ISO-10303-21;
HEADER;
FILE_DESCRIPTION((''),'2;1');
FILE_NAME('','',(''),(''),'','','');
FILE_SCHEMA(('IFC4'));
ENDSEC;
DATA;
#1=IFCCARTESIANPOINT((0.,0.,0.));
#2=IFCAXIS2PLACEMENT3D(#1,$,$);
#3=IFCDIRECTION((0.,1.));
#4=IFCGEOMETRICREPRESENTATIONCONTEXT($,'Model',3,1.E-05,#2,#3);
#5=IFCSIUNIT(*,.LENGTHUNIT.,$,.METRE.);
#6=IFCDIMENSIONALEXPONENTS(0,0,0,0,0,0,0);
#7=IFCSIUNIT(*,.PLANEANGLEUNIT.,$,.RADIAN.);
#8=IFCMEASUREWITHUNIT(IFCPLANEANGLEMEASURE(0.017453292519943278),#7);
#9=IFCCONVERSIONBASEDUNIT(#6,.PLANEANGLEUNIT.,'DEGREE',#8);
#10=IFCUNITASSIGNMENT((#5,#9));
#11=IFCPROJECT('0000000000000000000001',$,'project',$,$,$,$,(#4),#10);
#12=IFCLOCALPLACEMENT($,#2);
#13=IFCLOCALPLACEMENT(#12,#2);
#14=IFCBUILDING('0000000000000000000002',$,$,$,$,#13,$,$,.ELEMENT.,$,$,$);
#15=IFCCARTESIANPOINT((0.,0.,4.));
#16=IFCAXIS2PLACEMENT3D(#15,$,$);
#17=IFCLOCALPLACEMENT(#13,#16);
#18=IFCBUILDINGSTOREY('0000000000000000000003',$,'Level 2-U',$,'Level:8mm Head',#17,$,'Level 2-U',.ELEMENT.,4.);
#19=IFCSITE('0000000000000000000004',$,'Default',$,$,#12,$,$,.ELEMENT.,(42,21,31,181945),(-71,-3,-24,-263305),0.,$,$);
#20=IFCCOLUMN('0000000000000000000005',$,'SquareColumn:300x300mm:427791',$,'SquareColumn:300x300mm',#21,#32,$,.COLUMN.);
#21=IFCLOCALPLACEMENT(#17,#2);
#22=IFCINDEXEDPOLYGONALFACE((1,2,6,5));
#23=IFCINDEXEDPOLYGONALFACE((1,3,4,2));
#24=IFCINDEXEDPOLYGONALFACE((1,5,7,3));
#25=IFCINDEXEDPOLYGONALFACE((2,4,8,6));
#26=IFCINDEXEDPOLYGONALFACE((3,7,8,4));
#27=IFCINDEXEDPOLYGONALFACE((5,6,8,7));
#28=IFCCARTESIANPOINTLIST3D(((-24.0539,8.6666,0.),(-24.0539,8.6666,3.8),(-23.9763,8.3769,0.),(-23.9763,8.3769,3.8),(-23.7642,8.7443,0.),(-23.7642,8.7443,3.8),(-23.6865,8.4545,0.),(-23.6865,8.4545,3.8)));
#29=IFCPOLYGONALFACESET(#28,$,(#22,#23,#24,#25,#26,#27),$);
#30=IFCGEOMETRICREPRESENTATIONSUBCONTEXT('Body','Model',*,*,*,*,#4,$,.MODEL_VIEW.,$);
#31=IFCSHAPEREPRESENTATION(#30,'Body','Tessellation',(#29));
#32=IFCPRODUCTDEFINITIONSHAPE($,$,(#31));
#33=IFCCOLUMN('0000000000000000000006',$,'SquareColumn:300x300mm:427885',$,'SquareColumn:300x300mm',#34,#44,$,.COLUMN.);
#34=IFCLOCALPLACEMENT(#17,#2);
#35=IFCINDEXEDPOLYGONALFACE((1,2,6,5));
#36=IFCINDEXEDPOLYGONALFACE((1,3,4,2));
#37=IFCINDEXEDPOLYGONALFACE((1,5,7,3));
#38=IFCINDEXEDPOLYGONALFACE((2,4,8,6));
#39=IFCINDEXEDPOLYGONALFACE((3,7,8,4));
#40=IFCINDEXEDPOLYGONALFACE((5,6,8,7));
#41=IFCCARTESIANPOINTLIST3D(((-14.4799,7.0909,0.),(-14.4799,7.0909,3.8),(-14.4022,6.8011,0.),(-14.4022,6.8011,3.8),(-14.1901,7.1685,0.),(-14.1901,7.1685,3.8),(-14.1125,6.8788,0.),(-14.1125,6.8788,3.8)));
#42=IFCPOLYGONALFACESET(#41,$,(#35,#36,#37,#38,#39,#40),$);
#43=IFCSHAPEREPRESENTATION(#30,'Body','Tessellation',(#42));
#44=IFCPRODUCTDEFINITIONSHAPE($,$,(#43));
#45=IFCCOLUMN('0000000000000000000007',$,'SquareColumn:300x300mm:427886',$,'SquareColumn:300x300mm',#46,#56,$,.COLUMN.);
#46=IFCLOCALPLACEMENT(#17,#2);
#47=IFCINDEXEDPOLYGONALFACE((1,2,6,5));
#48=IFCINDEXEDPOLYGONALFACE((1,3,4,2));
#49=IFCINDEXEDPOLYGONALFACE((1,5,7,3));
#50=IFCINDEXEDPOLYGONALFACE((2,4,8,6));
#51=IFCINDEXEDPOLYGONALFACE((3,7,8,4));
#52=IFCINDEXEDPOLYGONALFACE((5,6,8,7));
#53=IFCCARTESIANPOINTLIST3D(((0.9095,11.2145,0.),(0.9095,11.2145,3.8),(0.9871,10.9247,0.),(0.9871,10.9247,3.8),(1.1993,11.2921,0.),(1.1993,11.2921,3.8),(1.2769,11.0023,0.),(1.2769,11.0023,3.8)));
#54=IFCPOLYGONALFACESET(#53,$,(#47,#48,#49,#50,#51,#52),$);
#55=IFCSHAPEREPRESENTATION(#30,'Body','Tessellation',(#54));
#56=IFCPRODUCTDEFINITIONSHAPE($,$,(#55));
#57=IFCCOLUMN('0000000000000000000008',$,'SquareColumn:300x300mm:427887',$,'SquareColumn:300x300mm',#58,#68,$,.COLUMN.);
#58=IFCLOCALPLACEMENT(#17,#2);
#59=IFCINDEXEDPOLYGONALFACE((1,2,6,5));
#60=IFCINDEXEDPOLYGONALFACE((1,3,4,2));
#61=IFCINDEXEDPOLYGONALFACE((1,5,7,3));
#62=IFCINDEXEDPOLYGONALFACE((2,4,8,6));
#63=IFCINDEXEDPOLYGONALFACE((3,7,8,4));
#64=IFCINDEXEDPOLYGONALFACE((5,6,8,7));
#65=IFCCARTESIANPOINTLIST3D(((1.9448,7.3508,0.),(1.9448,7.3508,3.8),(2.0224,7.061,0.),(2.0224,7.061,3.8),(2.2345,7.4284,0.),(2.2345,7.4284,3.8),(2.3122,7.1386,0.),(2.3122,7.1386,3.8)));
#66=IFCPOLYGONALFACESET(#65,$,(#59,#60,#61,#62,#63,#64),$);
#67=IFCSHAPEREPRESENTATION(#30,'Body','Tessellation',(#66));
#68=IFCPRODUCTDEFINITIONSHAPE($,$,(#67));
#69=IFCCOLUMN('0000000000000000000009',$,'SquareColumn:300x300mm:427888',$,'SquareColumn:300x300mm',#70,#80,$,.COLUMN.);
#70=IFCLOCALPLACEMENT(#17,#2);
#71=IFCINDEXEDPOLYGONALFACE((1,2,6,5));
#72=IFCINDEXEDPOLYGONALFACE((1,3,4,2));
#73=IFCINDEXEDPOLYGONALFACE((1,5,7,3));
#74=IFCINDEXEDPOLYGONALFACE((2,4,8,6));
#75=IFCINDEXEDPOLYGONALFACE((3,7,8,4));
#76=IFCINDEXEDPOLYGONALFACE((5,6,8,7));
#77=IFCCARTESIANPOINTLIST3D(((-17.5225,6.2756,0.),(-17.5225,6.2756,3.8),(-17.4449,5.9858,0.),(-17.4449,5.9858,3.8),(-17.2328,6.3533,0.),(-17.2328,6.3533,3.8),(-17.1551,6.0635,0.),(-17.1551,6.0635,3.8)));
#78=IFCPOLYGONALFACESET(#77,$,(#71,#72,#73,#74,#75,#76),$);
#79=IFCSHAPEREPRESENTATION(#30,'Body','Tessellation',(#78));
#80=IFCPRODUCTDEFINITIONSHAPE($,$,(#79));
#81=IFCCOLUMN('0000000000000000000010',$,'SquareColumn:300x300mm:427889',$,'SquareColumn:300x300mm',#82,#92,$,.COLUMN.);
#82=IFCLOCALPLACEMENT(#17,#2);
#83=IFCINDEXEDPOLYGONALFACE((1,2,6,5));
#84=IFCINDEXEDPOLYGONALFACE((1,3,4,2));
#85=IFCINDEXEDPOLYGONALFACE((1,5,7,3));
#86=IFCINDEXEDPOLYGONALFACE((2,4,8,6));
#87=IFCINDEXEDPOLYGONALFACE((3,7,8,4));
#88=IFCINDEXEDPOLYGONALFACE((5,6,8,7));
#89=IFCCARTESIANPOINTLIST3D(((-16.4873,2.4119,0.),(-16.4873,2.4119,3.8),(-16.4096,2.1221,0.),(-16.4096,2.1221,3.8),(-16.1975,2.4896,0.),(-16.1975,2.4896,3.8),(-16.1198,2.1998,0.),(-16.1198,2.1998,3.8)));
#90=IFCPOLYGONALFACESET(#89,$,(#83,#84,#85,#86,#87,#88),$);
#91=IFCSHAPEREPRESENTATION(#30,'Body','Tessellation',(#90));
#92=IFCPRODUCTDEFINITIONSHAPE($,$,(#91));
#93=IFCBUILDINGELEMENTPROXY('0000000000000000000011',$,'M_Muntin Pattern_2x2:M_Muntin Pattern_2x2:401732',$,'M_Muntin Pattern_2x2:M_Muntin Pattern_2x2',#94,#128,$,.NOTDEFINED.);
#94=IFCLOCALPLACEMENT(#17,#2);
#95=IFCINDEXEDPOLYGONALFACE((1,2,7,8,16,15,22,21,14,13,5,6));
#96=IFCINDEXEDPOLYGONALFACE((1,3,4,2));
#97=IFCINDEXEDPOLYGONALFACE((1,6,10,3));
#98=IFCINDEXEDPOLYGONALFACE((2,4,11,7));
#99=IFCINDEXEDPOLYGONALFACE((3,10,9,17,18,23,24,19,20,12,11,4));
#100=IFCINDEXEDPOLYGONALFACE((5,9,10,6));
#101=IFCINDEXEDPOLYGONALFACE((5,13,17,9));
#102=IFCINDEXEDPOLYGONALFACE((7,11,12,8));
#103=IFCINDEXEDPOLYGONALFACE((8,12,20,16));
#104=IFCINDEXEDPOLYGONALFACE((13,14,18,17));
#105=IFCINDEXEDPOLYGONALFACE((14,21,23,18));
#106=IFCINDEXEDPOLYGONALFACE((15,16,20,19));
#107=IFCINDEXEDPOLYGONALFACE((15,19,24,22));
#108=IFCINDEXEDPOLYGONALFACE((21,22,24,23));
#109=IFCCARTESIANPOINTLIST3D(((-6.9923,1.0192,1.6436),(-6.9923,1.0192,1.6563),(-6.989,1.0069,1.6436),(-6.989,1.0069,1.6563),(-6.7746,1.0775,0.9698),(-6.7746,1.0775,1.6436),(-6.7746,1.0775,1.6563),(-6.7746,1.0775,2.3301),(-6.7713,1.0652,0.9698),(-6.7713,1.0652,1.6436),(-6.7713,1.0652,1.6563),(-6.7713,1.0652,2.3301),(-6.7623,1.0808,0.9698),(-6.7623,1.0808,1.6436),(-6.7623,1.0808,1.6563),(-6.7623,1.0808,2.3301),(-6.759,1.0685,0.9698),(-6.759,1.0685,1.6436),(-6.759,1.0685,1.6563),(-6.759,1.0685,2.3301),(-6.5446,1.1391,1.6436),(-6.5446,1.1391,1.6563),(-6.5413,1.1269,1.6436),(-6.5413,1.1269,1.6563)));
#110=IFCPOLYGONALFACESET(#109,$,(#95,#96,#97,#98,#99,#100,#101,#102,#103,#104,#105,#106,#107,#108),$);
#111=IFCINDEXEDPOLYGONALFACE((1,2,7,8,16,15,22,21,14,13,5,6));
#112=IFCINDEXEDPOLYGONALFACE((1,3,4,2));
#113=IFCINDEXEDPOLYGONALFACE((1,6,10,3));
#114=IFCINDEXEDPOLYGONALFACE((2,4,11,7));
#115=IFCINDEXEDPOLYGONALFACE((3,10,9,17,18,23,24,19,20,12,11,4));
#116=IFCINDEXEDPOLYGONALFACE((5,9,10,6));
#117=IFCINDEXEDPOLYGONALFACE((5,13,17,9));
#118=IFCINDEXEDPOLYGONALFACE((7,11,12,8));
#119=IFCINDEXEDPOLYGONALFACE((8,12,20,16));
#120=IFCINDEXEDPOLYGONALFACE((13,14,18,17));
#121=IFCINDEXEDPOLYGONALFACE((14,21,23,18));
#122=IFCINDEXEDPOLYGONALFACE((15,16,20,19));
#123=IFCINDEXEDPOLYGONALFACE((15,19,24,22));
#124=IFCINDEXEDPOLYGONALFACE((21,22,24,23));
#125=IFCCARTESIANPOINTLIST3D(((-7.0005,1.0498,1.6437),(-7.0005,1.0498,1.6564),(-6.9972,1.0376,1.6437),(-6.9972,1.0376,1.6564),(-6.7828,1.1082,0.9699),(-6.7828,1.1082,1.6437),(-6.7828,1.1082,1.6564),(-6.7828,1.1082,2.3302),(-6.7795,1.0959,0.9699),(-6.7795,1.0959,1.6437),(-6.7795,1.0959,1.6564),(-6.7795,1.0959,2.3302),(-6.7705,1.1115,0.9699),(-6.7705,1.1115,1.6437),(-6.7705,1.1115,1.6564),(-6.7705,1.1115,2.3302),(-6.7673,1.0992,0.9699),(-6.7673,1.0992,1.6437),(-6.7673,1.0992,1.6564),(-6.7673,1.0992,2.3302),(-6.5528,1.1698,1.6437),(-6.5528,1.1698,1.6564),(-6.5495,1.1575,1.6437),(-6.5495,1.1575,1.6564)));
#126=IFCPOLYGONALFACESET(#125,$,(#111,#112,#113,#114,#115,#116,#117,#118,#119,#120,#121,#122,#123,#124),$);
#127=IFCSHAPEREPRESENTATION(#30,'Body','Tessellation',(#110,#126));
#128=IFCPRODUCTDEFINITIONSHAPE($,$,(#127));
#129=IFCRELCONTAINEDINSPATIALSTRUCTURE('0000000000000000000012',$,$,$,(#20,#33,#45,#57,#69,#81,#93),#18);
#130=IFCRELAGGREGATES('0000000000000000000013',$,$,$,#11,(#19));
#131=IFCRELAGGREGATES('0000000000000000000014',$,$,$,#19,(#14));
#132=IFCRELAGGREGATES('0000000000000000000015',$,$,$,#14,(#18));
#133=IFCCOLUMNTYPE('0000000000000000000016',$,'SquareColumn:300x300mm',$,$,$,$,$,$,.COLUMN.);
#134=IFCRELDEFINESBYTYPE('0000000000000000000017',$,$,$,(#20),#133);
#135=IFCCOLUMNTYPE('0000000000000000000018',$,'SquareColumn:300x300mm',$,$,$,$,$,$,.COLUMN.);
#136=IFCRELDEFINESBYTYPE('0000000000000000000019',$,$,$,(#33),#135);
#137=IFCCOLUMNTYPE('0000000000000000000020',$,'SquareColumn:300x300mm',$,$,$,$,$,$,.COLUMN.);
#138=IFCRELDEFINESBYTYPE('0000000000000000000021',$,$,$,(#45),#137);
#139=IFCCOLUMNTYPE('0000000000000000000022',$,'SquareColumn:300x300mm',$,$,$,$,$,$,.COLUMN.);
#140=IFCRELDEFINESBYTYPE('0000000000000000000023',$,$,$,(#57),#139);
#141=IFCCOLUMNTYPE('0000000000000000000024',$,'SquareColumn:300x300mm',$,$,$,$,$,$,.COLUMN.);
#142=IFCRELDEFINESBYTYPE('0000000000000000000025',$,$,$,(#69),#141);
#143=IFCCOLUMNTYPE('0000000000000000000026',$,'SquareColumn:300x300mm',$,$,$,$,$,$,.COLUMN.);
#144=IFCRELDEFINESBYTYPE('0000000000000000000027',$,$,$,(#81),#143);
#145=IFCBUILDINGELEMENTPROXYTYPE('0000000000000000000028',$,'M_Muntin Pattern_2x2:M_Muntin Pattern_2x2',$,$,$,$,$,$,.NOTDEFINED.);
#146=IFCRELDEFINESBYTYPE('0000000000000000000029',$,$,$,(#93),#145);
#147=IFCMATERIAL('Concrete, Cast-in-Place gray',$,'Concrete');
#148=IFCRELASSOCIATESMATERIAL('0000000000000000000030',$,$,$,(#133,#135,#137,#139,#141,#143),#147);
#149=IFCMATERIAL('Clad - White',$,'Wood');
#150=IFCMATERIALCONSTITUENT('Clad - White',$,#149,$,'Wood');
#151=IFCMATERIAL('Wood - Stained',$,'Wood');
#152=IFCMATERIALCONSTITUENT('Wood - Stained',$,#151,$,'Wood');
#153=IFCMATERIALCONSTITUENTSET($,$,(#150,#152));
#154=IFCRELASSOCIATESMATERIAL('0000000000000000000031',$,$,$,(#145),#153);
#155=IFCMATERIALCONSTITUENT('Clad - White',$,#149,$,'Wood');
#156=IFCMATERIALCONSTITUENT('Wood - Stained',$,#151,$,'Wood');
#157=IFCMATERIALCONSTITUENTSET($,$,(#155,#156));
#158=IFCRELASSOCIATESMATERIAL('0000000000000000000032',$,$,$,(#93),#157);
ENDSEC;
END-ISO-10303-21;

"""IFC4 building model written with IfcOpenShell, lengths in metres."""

from ifc_helpers import new_model, entity, si_unit, converted_unit, direction, frame, frame_2d, origin, origin_2d_with_axis, place, context, subcontext, project, spatial, polyline, rectangle, outline, extrude, source, transform, mapped, material, constituent, constituent_set, material_profile, profile_set, type_object, type_shapes, element, save


model = new_model("IFC4")

# Units and contexts
model_context = context("Model", 3, precision=1e-05, world=origin(), true_north=direction((0.0, 1.0)))
body_context = subcontext(model_context, "Body", "Model", "MODEL_VIEW")
ifc_project = project(units=[si_unit("LENGTHUNIT", "METRE"), converted_unit("PLANEANGLEUNIT", "DEGREE", entity("IfcPlaneAngleMeasure", 0.017453292519943278), si_unit("PLANEANGLEUNIT", "RADIAN"), dimensions=[0, 0, 0, 0, 0, 0, 0])], contexts=[model_context])

# Site, building, storey
site_placement = place(None, origin())
site = spatial("IfcSite", under=ifc_project, at=site_placement, Name="Default", CompositionType="ELEMENT", RefLatitude=(42, 21, 31, 181945), RefLongitude=(-71, -3, -24, -263305), RefElevation=0.0)
building_placement = place(site_placement, origin())
building = spatial("IfcBuilding", under=site, at=building_placement, CompositionType="ELEMENT")
storey_placement = place(building_placement, frame((0.0, 0.0, 4.0)))
storey = spatial("IfcBuildingStorey", under=building, at=storey_placement, Name="Level 2-U", ObjectType="Level:8mm Head", LongName="Level 2-U", CompositionType="ELEMENT", Elevation=4.0)

# Columns
ifc_material_1 = material(Name="Concrete, Cast-in-Place gray", Category="Concrete")
ifc_material_profile = material_profile(ifc_material_1, rectangle(XDim=0.3, YDim=0.3, at=origin_2d_with_axis()), Name="300x300mm")
ifc_profile_set = profile_set([ifc_material_profile], Name="300x300mm")
column_type_1 = type_object("IfcColumnType", Name="SquareColumn:300x300mm", PredefinedType="COLUMN", material=ifc_profile_set)
shared_shape_1 = source(origin(), body_context, "Body", "SweptSolid", [
    extrude(rectangle(XDim=0.3, YDim=0.3, at=origin_2d_with_axis()), frame((-23.8702, 8.5606, 4.0), z_axis=(0.0, 0.0, 1.0), x_axis=(-0.258819, 0.965926, 0.0)), (0.0, 0.0, 1.0), 3.8),
])
type_shapes(column_type_1, [shared_shape_1])
column_1_placement = place(storey_placement, frame((0.0, 0.0, -4.0)))
element("IfcColumn", 1, at=column_1_placement, inside=storey, type_object=column_type_1, Name="SquareColumn:300x300mm:427791", ObjectType="SquareColumn:300x300mm", PredefinedType="COLUMN", context=body_context, shape_type="MappedRepresentation", body=[
    mapped(shared_shape_1, transform((0.0, 0.0, 0.0), scale=1.0)),
])
column_type_2 = type_object("IfcColumnType", Name="SquareColumn:300x300mm", PredefinedType="COLUMN", material=ifc_profile_set)
shared_shape_2 = source(origin(), body_context, "Body", "SweptSolid", [
    extrude(rectangle(XDim=0.3, YDim=0.3, at=frame_2d((0.0, 0.0), x_axis=(1.0, 0.0))), frame((-14.2962, 6.9848, 4.0), z_axis=(0.0, 0.0, 1.0), x_axis=(-0.258819, 0.965926, 0.0)), (0.0, 0.0, 1.0), 3.8),
])
type_shapes(column_type_2, [shared_shape_2])
column_2_placement = place(storey_placement, frame((0.0, 0.0, -4.0)))
element("IfcColumn", 2, at=column_2_placement, inside=storey, type_object=column_type_2, Name="SquareColumn:300x300mm:427885", ObjectType="SquareColumn:300x300mm", PredefinedType="COLUMN", context=body_context, shape_type="MappedRepresentation", body=[
    mapped(shared_shape_2, transform((0.0, 0.0, 0.0), scale=1.0)),
])
column_type_3 = type_object("IfcColumnType", Name="SquareColumn:300x300mm", PredefinedType="COLUMN", material=ifc_profile_set)
shared_shape_3 = source(origin(), body_context, "Body", "SweptSolid", [
    extrude(rectangle(XDim=0.3, YDim=0.3, at=frame_2d((0.0, 0.0), x_axis=(1.0, 0.0))), frame((1.0932, 11.1084, 4.0), z_axis=(0.0, 0.0, 1.0), x_axis=(-0.258819, 0.965926, 0.0)), (0.0, 0.0, 1.0), 3.8),
])
type_shapes(column_type_3, [shared_shape_3])
column_3_placement = place(storey_placement, frame((0.0, 0.0, -4.0)))
element("IfcColumn", 3, at=column_3_placement, inside=storey, type_object=column_type_3, Name="SquareColumn:300x300mm:427886", ObjectType="SquareColumn:300x300mm", PredefinedType="COLUMN", context=body_context, shape_type="MappedRepresentation", body=[
    mapped(shared_shape_3, transform((0.0, 0.0, 0.0), scale=1.0)),
])
column_type_4 = type_object("IfcColumnType", Name="SquareColumn:300x300mm", PredefinedType="COLUMN", material=ifc_profile_set)
shared_shape_4 = source(origin(), body_context, "Body", "SweptSolid", [
    extrude(rectangle(XDim=0.3, YDim=0.3, at=frame_2d((0.0, 0.0), x_axis=(1.0, 0.0))), frame((2.1285, 7.2447, 4.0), z_axis=(0.0, 0.0, 1.0), x_axis=(-0.258819, 0.965926, 0.0)), (0.0, 0.0, 1.0), 3.8),
])
type_shapes(column_type_4, [shared_shape_4])
column_4_placement = place(storey_placement, frame((0.0, 0.0, -4.0)))
element("IfcColumn", 4, at=column_4_placement, inside=storey, type_object=column_type_4, Name="SquareColumn:300x300mm:427887", ObjectType="SquareColumn:300x300mm", PredefinedType="COLUMN", context=body_context, shape_type="MappedRepresentation", body=[
    mapped(shared_shape_4, transform((0.0, 0.0, 0.0), scale=1.0)),
])
column_type_5 = type_object("IfcColumnType", Name="SquareColumn:300x300mm", PredefinedType="COLUMN", material=ifc_profile_set)
shared_shape_5 = source(origin(), body_context, "Body", "SweptSolid", [
    extrude(rectangle(XDim=0.3, YDim=0.3, at=origin_2d_with_axis()), frame((-17.3388, 6.1695, 4.0), z_axis=(0.0, 0.0, 1.0), x_axis=(-0.258819, 0.965926, 0.0)), (0.0, 0.0, 1.0), 3.8),
])
type_shapes(column_type_5, [shared_shape_5])
column_5_placement = place(storey_placement, frame((0.0, 0.0, -4.0)))
element("IfcColumn", 5, at=column_5_placement, inside=storey, type_object=column_type_5, Name="SquareColumn:300x300mm:427888", ObjectType="SquareColumn:300x300mm", PredefinedType="COLUMN", context=body_context, shape_type="MappedRepresentation", body=[
    mapped(shared_shape_5, transform((0.0, 0.0, 0.0), scale=1.0)),
])
column_type_6 = type_object("IfcColumnType", Name="SquareColumn:300x300mm", PredefinedType="COLUMN", material=ifc_profile_set)
shared_shape_6 = source(origin(), body_context, "Body", "SweptSolid", [
    extrude(rectangle(XDim=0.3, YDim=0.3, at=origin_2d_with_axis()), frame((-16.3036, 2.3058, 4.0), z_axis=(0.0, 0.0, 1.0), x_axis=(-0.258819, 0.965926, 0.0)), (0.0, 0.0, 1.0), 3.8),
])
type_shapes(column_type_6, [shared_shape_6])
column_6_placement = place(storey_placement, frame((0.0, 0.0, -4.0)))
element("IfcColumn", 6, at=column_6_placement, inside=storey, type_object=column_type_6, Name="SquareColumn:300x300mm:427889", ObjectType="SquareColumn:300x300mm", PredefinedType="COLUMN", context=body_context, shape_type="MappedRepresentation", body=[
    mapped(shared_shape_6, transform((0.0, 0.0, 0.0), scale=1.0)),
])

# Building element proxy
ifc_material_2 = material(Name="Clad - White", Category="Wood")
ifc_constituent_1 = constituent(ifc_material_2, Name="Clad - White", Category="Wood")
ifc_material_3 = material(Name="Wood - Stained", Category="Wood")
ifc_constituent_2 = constituent(ifc_material_3, Name="Wood - Stained", Category="Wood")
ifc_constituent_set_1 = constituent_set(constituents=[ifc_constituent_1, ifc_constituent_2])
ifc_constituent_3 = constituent(ifc_material_2, Name="Clad - White", Category="Wood")
ifc_constituent_4 = constituent(ifc_material_3, Name="Wood - Stained", Category="Wood")
ifc_constituent_set_2 = constituent_set(constituents=[ifc_constituent_3, ifc_constituent_4])
building_element_proxy_type = type_object("IfcBuildingElementProxyType", Name="M_Muntin Pattern_2x2:M_Muntin Pattern_2x2", PredefinedType="NOTDEFINED", material=ifc_constituent_set_2)
shared_shape_7 = source(origin(), body_context, "Body", "SweptSolid", [
    extrude(outline(polyline([(0.0064, -0.0064), (0.6801, -0.0064), (0.6801, 0.0063), (0.0064, 0.0063), (0.0064, 0.2317), (-0.0063, 0.2317), (-0.0063, 0.0063), (-0.6802, 0.0063), (-0.6802, -0.0064), (-0.0063, -0.0064), (-0.0063, -0.2317), (0.0064, -0.2317), (0.0064, -0.0064)])), frame((0.0, -0.0222, 0.6801), z_axis=(0.0, 1.0, 0.0), x_axis=(0.0, 0.0, 1.0)), (0.0, 0.0, 1.0), 0.0127),
    extrude(outline(polyline([(0.0064, -0.0064), (0.6802, -0.0064), (0.6802, 0.0063), (0.0064, 0.0063), (0.0064, 0.2317), (-0.0063, 0.2317), (-0.0063, 0.0063), (-0.6802, 0.0063), (-0.6802, -0.0064), (-0.0063, -0.0064), (-0.0063, -0.2317), (0.0064, -0.2317), (0.0064, -0.0064)])), frame((0.0, 0.0095, 0.6802), z_axis=(0.0, 1.0, 0.0), x_axis=(0.0, 0.0, 1.0)), (0.0, 0.0, 1.0), 0.0127),
])
type_shapes(building_element_proxy_type, [shared_shape_7])
proxy_placement = place(storey_placement, frame((-6.7709, 1.0884, 0.9699), z_axis=(0.0, 0.0, 1.0), x_axis=(0.965926, 0.258819, 0.0)))
element("IfcBuildingElementProxy", 7, at=proxy_placement, inside=storey, type_object=building_element_proxy_type, material=ifc_constituent_set_1, Name="M_Muntin Pattern_2x2:M_Muntin Pattern_2x2:401732", ObjectType="M_Muntin Pattern_2x2:M_Muntin Pattern_2x2", PredefinedType="NOTDEFINED", context=body_context, shape_type="MappedRepresentation", body=[
    mapped(shared_shape_7, transform((0.0, 0.0, 0.0), scale=1.0)),
])

save(model, "model.ifc")
